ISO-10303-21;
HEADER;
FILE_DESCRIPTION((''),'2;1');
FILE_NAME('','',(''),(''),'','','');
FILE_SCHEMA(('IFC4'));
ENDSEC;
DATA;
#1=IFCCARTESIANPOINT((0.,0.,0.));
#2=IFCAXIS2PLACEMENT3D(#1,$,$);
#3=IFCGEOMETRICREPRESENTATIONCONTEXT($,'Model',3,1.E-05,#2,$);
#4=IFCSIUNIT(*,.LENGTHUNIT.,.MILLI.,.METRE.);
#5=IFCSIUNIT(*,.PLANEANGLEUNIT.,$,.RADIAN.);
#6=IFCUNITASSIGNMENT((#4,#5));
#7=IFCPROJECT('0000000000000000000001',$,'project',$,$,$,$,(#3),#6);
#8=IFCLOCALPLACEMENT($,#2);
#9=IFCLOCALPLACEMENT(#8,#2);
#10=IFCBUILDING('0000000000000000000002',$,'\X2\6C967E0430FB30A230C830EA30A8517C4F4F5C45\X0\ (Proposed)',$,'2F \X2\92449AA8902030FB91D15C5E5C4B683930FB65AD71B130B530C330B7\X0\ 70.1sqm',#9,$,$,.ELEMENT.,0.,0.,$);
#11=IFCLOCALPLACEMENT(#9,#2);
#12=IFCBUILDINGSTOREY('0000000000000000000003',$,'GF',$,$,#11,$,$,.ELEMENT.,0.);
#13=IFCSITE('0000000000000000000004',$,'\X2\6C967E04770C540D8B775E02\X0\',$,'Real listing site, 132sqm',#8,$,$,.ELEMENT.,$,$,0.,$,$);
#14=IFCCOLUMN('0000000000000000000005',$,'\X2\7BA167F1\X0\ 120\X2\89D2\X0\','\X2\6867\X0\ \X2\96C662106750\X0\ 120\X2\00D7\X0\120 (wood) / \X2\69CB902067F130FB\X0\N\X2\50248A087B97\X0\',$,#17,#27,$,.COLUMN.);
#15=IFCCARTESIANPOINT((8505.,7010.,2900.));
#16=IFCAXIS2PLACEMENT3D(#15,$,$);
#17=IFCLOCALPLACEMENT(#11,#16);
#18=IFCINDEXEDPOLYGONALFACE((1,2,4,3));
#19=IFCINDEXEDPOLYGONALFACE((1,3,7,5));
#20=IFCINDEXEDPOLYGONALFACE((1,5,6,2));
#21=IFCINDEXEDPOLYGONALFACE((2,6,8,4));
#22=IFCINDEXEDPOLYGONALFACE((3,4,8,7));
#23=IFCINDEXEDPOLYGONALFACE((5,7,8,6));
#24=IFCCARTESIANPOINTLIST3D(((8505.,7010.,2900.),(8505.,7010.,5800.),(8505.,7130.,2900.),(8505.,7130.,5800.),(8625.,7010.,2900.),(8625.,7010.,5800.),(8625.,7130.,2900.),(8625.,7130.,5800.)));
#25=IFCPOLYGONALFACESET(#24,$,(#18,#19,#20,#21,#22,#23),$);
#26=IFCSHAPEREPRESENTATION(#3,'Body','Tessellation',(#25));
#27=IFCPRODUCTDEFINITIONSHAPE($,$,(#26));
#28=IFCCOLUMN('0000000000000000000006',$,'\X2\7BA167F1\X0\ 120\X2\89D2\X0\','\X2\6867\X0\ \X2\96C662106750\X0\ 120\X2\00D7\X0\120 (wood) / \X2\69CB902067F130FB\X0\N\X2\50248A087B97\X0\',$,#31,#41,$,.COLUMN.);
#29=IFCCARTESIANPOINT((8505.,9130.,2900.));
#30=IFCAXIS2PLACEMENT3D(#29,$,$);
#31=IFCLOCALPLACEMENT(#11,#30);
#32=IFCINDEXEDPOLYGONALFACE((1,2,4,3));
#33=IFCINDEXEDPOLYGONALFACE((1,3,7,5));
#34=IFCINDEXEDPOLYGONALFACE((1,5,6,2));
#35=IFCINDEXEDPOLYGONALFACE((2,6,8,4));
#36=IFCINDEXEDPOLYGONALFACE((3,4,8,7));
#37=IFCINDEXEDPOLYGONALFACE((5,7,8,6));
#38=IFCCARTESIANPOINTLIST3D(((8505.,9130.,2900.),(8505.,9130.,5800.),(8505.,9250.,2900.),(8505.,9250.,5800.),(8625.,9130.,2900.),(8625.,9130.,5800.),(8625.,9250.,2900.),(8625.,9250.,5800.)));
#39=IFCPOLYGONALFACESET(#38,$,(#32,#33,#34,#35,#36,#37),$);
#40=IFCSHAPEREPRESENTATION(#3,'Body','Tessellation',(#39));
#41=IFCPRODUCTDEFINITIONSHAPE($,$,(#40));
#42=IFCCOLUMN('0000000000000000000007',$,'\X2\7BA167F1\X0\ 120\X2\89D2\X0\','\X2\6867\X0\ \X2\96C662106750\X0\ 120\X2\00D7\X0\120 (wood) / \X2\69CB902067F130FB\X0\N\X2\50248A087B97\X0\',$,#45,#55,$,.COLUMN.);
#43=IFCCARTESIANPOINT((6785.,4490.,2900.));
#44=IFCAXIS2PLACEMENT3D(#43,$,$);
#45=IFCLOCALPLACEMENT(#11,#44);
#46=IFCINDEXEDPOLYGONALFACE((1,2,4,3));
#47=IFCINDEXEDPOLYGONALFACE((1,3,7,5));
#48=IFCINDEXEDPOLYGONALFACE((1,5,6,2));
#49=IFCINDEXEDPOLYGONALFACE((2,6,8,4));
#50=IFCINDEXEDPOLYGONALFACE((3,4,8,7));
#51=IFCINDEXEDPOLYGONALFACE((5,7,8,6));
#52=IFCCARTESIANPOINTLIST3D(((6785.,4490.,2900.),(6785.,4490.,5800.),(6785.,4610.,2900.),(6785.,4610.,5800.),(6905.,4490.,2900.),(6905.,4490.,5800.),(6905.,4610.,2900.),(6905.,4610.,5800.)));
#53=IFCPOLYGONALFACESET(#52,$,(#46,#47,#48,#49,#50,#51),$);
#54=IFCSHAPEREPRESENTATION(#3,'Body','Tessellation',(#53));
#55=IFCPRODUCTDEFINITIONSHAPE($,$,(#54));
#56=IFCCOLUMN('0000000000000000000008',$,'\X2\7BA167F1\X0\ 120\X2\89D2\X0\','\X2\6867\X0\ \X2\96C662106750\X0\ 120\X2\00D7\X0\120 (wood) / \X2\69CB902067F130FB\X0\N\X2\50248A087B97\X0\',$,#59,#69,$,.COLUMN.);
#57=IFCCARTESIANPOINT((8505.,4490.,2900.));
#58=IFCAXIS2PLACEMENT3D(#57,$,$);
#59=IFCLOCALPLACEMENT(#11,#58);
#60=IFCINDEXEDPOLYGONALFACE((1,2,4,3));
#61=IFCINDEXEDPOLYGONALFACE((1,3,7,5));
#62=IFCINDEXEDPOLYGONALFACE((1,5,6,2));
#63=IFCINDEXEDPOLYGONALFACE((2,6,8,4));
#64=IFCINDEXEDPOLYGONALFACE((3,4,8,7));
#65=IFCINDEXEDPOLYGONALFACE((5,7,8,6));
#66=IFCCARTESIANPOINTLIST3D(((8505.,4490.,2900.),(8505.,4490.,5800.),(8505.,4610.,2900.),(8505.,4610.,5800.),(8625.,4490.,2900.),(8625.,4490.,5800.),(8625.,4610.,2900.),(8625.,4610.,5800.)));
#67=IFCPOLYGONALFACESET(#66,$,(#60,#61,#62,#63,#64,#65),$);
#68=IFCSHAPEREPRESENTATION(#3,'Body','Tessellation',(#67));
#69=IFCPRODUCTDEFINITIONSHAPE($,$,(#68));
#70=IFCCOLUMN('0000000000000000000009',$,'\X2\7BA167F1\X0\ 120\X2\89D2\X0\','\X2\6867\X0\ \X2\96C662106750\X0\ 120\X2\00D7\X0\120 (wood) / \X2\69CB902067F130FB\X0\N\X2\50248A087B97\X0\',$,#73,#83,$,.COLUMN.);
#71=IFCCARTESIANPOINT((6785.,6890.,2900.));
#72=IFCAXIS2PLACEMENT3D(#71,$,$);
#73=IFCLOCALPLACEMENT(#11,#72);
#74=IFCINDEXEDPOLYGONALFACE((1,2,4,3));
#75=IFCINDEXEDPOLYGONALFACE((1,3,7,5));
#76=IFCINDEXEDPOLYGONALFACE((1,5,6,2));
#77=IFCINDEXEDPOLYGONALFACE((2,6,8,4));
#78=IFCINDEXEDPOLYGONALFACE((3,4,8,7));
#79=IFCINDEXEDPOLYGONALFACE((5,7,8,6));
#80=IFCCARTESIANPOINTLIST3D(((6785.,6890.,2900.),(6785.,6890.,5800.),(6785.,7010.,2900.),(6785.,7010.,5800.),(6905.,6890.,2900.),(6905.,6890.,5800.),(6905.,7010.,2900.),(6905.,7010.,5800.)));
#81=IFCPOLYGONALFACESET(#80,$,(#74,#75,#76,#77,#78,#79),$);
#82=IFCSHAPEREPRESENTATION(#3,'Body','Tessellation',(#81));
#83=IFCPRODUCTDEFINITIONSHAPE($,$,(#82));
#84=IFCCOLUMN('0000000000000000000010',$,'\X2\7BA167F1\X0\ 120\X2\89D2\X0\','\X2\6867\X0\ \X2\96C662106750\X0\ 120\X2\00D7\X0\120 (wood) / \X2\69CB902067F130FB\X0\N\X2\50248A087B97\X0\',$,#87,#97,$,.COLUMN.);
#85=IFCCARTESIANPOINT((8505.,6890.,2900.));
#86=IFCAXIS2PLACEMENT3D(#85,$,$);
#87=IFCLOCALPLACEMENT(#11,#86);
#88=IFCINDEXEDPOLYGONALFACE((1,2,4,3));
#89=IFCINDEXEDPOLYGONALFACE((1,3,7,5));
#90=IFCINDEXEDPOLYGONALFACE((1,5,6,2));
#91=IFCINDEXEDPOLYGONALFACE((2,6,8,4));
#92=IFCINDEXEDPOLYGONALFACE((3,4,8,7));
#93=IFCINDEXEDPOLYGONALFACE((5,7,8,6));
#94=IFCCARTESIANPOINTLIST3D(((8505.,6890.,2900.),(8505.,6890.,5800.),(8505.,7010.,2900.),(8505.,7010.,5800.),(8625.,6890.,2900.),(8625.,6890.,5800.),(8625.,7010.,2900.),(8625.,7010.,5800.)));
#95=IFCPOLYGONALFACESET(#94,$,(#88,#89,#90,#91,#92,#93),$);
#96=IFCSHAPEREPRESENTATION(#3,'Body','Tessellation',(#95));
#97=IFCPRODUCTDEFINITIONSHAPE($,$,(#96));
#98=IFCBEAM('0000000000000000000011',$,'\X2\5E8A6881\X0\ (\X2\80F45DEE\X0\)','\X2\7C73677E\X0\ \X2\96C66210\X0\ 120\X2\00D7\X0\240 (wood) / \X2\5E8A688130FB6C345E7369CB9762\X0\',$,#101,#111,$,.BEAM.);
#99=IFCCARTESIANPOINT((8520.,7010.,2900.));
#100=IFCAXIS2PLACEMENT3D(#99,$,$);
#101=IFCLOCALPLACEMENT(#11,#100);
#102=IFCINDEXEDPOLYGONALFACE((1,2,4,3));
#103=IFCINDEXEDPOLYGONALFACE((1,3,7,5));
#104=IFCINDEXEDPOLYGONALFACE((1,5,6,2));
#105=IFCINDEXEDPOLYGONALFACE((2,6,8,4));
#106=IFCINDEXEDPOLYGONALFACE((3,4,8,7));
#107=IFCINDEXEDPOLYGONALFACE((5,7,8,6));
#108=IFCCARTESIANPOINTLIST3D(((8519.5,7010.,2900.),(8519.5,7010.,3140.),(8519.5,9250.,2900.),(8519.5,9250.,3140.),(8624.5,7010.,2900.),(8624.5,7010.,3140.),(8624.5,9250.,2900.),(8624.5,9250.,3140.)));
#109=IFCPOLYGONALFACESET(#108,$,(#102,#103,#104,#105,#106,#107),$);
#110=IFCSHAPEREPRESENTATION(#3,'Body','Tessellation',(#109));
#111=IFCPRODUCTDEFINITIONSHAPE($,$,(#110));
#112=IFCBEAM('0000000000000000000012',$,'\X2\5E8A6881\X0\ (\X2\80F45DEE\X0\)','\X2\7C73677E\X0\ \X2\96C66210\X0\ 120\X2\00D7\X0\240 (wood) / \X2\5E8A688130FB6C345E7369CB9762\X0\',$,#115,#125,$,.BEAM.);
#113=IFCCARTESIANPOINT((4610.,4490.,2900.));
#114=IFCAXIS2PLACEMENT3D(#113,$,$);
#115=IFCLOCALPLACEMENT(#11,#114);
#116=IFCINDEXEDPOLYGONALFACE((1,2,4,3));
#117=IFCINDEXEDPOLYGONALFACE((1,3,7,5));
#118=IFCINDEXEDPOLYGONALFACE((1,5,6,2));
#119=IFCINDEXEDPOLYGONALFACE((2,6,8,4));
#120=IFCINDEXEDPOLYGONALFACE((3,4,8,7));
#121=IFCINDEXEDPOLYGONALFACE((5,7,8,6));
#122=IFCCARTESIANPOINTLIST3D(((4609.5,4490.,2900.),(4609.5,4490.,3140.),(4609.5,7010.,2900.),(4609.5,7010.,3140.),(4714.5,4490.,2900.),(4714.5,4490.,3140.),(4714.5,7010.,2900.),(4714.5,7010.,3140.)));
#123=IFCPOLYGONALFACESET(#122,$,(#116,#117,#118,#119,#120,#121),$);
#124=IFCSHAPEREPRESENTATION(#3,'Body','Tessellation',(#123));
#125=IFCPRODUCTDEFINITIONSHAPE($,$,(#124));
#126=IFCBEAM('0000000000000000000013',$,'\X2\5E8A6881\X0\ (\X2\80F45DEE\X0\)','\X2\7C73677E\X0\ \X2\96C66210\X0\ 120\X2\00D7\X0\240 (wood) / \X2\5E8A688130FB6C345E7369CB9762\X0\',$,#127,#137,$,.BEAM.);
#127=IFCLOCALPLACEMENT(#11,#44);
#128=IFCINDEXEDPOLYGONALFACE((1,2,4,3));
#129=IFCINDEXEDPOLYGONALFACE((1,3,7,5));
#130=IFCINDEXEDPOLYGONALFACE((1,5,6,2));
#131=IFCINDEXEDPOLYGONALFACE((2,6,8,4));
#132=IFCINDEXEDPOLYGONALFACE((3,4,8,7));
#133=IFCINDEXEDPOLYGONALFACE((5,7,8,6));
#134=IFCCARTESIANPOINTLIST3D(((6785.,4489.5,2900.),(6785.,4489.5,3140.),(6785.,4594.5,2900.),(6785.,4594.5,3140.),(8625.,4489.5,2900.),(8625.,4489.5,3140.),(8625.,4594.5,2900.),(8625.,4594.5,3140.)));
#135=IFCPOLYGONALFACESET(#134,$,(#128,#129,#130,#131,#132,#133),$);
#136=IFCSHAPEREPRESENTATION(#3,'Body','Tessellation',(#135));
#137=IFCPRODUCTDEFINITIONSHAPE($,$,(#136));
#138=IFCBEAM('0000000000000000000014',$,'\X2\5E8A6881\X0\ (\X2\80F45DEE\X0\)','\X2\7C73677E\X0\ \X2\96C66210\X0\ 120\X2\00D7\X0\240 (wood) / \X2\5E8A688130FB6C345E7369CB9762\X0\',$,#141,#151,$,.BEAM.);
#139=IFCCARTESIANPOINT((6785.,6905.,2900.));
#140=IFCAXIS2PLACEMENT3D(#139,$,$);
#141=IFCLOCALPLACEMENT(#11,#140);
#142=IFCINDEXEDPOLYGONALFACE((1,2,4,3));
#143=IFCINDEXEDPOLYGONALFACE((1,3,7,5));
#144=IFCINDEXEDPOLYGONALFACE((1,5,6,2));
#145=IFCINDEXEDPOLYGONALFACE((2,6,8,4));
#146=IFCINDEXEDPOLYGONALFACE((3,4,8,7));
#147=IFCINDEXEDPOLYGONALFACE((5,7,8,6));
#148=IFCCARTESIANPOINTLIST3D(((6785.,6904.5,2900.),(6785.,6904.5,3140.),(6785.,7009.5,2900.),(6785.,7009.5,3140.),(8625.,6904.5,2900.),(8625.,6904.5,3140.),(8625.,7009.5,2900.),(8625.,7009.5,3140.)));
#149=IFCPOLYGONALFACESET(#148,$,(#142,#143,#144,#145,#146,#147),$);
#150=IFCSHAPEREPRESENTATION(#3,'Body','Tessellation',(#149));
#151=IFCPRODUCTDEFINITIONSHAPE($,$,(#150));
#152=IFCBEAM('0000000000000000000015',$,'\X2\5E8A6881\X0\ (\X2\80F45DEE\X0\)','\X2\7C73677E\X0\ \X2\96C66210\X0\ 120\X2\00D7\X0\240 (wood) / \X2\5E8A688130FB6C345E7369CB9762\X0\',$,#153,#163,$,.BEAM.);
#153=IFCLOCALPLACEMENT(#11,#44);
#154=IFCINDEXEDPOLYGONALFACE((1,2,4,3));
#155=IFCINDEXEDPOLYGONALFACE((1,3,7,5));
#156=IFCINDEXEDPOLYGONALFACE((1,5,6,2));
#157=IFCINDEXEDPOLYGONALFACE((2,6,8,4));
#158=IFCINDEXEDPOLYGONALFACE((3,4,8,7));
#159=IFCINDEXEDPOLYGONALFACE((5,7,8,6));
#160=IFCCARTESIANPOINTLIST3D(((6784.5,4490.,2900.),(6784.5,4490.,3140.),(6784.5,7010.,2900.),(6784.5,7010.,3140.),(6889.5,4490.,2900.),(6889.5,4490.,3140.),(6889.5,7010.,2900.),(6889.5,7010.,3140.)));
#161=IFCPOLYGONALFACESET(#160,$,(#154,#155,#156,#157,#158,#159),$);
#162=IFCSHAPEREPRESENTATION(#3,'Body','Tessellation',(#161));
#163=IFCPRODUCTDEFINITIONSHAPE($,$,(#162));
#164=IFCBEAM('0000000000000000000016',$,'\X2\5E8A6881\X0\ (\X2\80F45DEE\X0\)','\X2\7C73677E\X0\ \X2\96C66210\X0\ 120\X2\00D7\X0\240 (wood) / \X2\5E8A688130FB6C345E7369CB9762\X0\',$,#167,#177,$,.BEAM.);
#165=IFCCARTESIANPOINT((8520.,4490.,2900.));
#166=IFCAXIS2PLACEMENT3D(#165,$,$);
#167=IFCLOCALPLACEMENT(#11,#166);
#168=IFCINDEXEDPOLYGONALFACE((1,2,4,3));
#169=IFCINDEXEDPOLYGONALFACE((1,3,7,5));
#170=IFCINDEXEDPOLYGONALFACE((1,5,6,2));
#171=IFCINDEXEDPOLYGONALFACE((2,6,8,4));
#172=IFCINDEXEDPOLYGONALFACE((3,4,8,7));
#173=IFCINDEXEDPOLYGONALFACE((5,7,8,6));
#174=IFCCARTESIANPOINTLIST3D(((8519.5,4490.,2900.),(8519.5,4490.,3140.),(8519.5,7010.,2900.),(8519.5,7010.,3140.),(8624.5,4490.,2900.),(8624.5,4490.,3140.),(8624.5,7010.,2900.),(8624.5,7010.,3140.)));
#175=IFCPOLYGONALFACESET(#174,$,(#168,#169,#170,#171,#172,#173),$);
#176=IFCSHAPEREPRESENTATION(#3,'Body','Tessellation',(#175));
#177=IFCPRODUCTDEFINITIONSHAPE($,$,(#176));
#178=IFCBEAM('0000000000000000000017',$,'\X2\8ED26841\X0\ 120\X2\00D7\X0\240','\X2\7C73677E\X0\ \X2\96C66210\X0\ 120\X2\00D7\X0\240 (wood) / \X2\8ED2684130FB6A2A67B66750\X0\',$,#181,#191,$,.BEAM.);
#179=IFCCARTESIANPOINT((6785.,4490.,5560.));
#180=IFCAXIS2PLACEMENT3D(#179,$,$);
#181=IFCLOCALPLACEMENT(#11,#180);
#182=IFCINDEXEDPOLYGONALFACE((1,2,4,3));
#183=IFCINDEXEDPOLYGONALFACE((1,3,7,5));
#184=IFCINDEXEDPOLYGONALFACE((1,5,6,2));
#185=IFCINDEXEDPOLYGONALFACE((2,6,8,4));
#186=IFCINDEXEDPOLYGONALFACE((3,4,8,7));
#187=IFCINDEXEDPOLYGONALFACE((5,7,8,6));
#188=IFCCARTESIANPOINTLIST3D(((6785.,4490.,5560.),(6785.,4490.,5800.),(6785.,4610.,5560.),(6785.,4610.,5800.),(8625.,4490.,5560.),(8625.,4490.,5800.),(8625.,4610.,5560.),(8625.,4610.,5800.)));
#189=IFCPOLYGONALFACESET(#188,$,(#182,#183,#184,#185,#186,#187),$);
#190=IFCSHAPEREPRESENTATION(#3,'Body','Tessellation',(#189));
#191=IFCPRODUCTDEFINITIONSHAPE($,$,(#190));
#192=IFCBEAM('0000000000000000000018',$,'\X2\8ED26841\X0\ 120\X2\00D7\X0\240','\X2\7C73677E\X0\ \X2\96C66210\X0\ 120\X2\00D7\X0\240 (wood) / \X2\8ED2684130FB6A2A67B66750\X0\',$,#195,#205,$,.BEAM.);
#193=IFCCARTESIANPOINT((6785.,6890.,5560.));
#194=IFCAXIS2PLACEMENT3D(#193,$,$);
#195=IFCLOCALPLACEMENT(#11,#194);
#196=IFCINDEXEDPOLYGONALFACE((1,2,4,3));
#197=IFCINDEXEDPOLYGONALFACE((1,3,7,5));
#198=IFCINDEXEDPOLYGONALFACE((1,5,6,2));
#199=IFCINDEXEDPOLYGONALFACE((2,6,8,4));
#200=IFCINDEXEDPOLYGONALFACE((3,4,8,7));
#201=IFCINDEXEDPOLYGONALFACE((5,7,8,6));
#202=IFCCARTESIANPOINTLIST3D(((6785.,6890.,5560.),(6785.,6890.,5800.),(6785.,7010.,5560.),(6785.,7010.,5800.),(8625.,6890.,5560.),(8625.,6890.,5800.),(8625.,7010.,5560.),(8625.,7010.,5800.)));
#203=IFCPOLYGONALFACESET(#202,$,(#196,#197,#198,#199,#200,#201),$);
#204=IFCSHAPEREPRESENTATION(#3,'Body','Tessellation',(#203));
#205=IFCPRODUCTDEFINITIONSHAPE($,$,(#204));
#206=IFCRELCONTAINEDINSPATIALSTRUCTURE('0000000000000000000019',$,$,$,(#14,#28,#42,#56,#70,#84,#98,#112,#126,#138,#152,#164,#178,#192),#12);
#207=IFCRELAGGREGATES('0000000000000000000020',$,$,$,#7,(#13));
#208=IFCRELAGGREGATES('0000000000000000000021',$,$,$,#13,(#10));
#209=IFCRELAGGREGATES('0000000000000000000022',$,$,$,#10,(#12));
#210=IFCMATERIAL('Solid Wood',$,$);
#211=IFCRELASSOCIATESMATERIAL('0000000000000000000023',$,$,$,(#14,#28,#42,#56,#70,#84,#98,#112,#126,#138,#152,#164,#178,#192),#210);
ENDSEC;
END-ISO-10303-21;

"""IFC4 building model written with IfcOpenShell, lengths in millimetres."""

from ifc_helpers import new_model, si_unit, frame, frame_2d, origin, place, context, project, spatial, rectangle, extrude, material, element, save


model = new_model("IFC4")

# Units and contexts
model_context = context("Model", 3, precision=1e-05, world=origin())
ifc_project = project(units=[si_unit("LENGTHUNIT", "METRE", prefix="MILLI"), si_unit("PLANEANGLEUNIT", "RADIAN")], contexts=[model_context])

# Site, building, storey
site_placement = place(None, origin())
site = spatial("IfcSite", under=ifc_project, at=site_placement, Name="沖縄県名護市", ObjectType="Real listing site, 132sqm", CompositionType="ELEMENT", RefElevation=0.0)
building_placement = place(site_placement, origin())
building = spatial("IfcBuilding", under=site, at=building_placement, Name="沖縄・アトリエ兼住居 (Proposed)", ObjectType="2F 鉄骨造・金属屋根・断熱サッシ 70.1sqm", CompositionType="ELEMENT", ElevationOfRefHeight=0.0, ElevationOfTerrain=0.0)
storey_placement = place(building_placement, origin())
storey = spatial("IfcBuildingStorey", under=building, at=storey_placement, Name="GF", CompositionType="ELEMENT", Elevation=0.0)

# Columns
ifc_material_1 = material(Name="Solid Wood")
column_1_placement = place(storey_placement, frame((8505.0, 7010.0, 2900.0)))
element("IfcColumn", 1, at=column_1_placement, inside=storey, material=ifc_material_1, Name="管柱 120角", Description="桧 集成材 120×120 (wood) / 構造柱・N値計算", PredefinedType="COLUMN", context=model_context, shape_type="SweptSolid", body=[
    extrude(rectangle(XDim=120.0, YDim=120.0, at=frame_2d((60.0, 60.0))), frame((8505.0, 7010.0, 2900.0)), (0.0, 0.0, 1.0), 2900.0),
])
column_2_placement = place(storey_placement, frame((8505.0, 9130.0, 2900.0)))
element("IfcColumn", 2, at=column_2_placement, inside=storey, material=ifc_material_1, Name="管柱 120角", Description="桧 集成材 120×120 (wood) / 構造柱・N値計算", PredefinedType="COLUMN", context=model_context, shape_type="SweptSolid", body=[
    extrude(rectangle(XDim=120.0, YDim=120.0, at=frame_2d((60.0, 60.0))), frame((8505.0, 9130.0, 2900.0)), (0.0, 0.0, 1.0), 2900.0),
])
column_3_placement = place(storey_placement, frame((6785.0, 4490.0, 2900.0)))
element("IfcColumn", 3, at=column_3_placement, inside=storey, material=ifc_material_1, Name="管柱 120角", Description="桧 集成材 120×120 (wood) / 構造柱・N値計算", PredefinedType="COLUMN", context=model_context, shape_type="SweptSolid", body=[
    extrude(rectangle(XDim=120.0, YDim=120.0, at=frame_2d((60.0, 60.0))), frame((6785.0, 4490.0, 2900.0)), (0.0, 0.0, 1.0), 2900.0),
])
column_4_placement = place(storey_placement, frame((8505.0, 4490.0, 2900.0)))
element("IfcColumn", 4, at=column_4_placement, inside=storey, material=ifc_material_1, Name="管柱 120角", Description="桧 集成材 120×120 (wood) / 構造柱・N値計算", PredefinedType="COLUMN", context=model_context, shape_type="SweptSolid", body=[
    extrude(rectangle(XDim=120.0, YDim=120.0, at=frame_2d((60.0, 60.0))), frame((8505.0, 4490.0, 2900.0)), (0.0, 0.0, 1.0), 2900.0),
])
column_5_placement = place(storey_placement, frame((6785.0, 6890.0, 2900.0)))
element("IfcColumn", 5, at=column_5_placement, inside=storey, material=ifc_material_1, Name="管柱 120角", Description="桧 集成材 120×120 (wood) / 構造柱・N値計算", PredefinedType="COLUMN", context=model_context, shape_type="SweptSolid", body=[
    extrude(rectangle(XDim=120.0, YDim=120.0, at=frame_2d((60.0, 60.0))), frame((6785.0, 6890.0, 2900.0)), (0.0, 0.0, 1.0), 2900.0),
])
column_6_placement = place(storey_placement, frame((8505.0, 6890.0, 2900.0)))
element("IfcColumn", 6, at=column_6_placement, inside=storey, material=ifc_material_1, Name="管柱 120角", Description="桧 集成材 120×120 (wood) / 構造柱・N値計算", PredefinedType="COLUMN", context=model_context, shape_type="SweptSolid", body=[
    extrude(rectangle(XDim=120.0, YDim=120.0, at=frame_2d((60.0, 60.0))), frame((8505.0, 6890.0, 2900.0)), (0.0, 0.0, 1.0), 2900.0),
])

# Beams
beam_1_placement = place(storey_placement, frame((8520.0, 7010.0, 2900.0)))
element("IfcBeam", 7, at=beam_1_placement, inside=storey, material=ifc_material_1, Name="床梁 (胴差)", Description="米松 集成 120×240 (wood) / 床梁・水平構面", PredefinedType="BEAM", context=model_context, shape_type="SweptSolid", body=[
    extrude(rectangle(XDim=105.0, YDim=2240.0, at=frame_2d((52.0, 1120.0))), frame((8520.0, 7010.0, 2900.0)), (0.0, 0.0, 1.0), 240.0),
])
beam_2_placement = place(storey_placement, frame((4610.0, 4490.0, 2900.0)))
element("IfcBeam", 8, at=beam_2_placement, inside=storey, material=ifc_material_1, Name="床梁 (胴差)", Description="米松 集成 120×240 (wood) / 床梁・水平構面", PredefinedType="BEAM", context=model_context, shape_type="SweptSolid", body=[
    extrude(rectangle(XDim=105.0, YDim=2520.0, at=frame_2d((52.0, 1260.0))), frame((4610.0, 4490.0, 2900.0)), (0.0, 0.0, 1.0), 240.0),
])
beam_3_placement = place(storey_placement, frame((6785.0, 4490.0, 2900.0)))
element("IfcBeam", 9, at=beam_3_placement, inside=storey, material=ifc_material_1, Name="床梁 (胴差)", Description="米松 集成 120×240 (wood) / 床梁・水平構面", PredefinedType="BEAM", context=model_context, shape_type="SweptSolid", body=[
    extrude(rectangle(XDim=1840.0, YDim=105.0, at=frame_2d((920.0, 52.0))), frame((6785.0, 4490.0, 2900.0)), (0.0, 0.0, 1.0), 240.0),
])
beam_4_placement = place(storey_placement, frame((6785.0, 6905.0, 2900.0)))
element("IfcBeam", 10, at=beam_4_placement, inside=storey, material=ifc_material_1, Name="床梁 (胴差)", Description="米松 集成 120×240 (wood) / 床梁・水平構面", PredefinedType="BEAM", context=model_context, shape_type="SweptSolid", body=[
    extrude(rectangle(XDim=1840.0, YDim=105.0, at=frame_2d((920.0, 52.0))), frame((6785.0, 6905.0, 2900.0)), (0.0, 0.0, 1.0), 240.0),
])
beam_5_placement = place(storey_placement, frame((6785.0, 4490.0, 2900.0)))
element("IfcBeam", 11, at=beam_5_placement, inside=storey, material=ifc_material_1, Name="床梁 (胴差)", Description="米松 集成 120×240 (wood) / 床梁・水平構面", PredefinedType="BEAM", context=model_context, shape_type="SweptSolid", body=[
    extrude(rectangle(XDim=105.0, YDim=2520.0, at=frame_2d((52.0, 1260.0))), frame((6785.0, 4490.0, 2900.0)), (0.0, 0.0, 1.0), 240.0),
])
beam_6_placement = place(storey_placement, frame((8520.0, 4490.0, 2900.0)))
element("IfcBeam", 12, at=beam_6_placement, inside=storey, material=ifc_material_1, Name="床梁 (胴差)", Description="米松 集成 120×240 (wood) / 床梁・水平構面", PredefinedType="BEAM", context=model_context, shape_type="SweptSolid", body=[
    extrude(rectangle(XDim=105.0, YDim=2520.0, at=frame_2d((52.0, 1260.0))), frame((8520.0, 4490.0, 2900.0)), (0.0, 0.0, 1.0), 240.0),
])
beam_7_placement = place(storey_placement, frame((6785.0, 4490.0, 5560.0)))
element("IfcBeam", 13, at=beam_7_placement, inside=storey, material=ifc_material_1, Name="軒桁 120×240", Description="米松 集成 120×240 (wood) / 軒桁・横架材", PredefinedType="BEAM", context=model_context, shape_type="SweptSolid", body=[
    extrude(rectangle(XDim=1840.0, YDim=120.0, at=frame_2d((920.0, 60.0))), frame((6785.0, 4490.0, 5560.0)), (0.0, 0.0, 1.0), 240.0),
])
beam_8_placement = place(storey_placement, frame((6785.0, 6890.0, 5560.0)))
element("IfcBeam", 14, at=beam_8_placement, inside=storey, material=ifc_material_1, Name="軒桁 120×240", Description="米松 集成 120×240 (wood) / 軒桁・横架材", PredefinedType="BEAM", context=model_context, shape_type="SweptSolid", body=[
    extrude(rectangle(XDim=1840.0, YDim=120.0, at=frame_2d((920.0, 60.0))), frame((6785.0, 6890.0, 5560.0)), (0.0, 0.0, 1.0), 240.0),
])

save(model, "model.ifc")
